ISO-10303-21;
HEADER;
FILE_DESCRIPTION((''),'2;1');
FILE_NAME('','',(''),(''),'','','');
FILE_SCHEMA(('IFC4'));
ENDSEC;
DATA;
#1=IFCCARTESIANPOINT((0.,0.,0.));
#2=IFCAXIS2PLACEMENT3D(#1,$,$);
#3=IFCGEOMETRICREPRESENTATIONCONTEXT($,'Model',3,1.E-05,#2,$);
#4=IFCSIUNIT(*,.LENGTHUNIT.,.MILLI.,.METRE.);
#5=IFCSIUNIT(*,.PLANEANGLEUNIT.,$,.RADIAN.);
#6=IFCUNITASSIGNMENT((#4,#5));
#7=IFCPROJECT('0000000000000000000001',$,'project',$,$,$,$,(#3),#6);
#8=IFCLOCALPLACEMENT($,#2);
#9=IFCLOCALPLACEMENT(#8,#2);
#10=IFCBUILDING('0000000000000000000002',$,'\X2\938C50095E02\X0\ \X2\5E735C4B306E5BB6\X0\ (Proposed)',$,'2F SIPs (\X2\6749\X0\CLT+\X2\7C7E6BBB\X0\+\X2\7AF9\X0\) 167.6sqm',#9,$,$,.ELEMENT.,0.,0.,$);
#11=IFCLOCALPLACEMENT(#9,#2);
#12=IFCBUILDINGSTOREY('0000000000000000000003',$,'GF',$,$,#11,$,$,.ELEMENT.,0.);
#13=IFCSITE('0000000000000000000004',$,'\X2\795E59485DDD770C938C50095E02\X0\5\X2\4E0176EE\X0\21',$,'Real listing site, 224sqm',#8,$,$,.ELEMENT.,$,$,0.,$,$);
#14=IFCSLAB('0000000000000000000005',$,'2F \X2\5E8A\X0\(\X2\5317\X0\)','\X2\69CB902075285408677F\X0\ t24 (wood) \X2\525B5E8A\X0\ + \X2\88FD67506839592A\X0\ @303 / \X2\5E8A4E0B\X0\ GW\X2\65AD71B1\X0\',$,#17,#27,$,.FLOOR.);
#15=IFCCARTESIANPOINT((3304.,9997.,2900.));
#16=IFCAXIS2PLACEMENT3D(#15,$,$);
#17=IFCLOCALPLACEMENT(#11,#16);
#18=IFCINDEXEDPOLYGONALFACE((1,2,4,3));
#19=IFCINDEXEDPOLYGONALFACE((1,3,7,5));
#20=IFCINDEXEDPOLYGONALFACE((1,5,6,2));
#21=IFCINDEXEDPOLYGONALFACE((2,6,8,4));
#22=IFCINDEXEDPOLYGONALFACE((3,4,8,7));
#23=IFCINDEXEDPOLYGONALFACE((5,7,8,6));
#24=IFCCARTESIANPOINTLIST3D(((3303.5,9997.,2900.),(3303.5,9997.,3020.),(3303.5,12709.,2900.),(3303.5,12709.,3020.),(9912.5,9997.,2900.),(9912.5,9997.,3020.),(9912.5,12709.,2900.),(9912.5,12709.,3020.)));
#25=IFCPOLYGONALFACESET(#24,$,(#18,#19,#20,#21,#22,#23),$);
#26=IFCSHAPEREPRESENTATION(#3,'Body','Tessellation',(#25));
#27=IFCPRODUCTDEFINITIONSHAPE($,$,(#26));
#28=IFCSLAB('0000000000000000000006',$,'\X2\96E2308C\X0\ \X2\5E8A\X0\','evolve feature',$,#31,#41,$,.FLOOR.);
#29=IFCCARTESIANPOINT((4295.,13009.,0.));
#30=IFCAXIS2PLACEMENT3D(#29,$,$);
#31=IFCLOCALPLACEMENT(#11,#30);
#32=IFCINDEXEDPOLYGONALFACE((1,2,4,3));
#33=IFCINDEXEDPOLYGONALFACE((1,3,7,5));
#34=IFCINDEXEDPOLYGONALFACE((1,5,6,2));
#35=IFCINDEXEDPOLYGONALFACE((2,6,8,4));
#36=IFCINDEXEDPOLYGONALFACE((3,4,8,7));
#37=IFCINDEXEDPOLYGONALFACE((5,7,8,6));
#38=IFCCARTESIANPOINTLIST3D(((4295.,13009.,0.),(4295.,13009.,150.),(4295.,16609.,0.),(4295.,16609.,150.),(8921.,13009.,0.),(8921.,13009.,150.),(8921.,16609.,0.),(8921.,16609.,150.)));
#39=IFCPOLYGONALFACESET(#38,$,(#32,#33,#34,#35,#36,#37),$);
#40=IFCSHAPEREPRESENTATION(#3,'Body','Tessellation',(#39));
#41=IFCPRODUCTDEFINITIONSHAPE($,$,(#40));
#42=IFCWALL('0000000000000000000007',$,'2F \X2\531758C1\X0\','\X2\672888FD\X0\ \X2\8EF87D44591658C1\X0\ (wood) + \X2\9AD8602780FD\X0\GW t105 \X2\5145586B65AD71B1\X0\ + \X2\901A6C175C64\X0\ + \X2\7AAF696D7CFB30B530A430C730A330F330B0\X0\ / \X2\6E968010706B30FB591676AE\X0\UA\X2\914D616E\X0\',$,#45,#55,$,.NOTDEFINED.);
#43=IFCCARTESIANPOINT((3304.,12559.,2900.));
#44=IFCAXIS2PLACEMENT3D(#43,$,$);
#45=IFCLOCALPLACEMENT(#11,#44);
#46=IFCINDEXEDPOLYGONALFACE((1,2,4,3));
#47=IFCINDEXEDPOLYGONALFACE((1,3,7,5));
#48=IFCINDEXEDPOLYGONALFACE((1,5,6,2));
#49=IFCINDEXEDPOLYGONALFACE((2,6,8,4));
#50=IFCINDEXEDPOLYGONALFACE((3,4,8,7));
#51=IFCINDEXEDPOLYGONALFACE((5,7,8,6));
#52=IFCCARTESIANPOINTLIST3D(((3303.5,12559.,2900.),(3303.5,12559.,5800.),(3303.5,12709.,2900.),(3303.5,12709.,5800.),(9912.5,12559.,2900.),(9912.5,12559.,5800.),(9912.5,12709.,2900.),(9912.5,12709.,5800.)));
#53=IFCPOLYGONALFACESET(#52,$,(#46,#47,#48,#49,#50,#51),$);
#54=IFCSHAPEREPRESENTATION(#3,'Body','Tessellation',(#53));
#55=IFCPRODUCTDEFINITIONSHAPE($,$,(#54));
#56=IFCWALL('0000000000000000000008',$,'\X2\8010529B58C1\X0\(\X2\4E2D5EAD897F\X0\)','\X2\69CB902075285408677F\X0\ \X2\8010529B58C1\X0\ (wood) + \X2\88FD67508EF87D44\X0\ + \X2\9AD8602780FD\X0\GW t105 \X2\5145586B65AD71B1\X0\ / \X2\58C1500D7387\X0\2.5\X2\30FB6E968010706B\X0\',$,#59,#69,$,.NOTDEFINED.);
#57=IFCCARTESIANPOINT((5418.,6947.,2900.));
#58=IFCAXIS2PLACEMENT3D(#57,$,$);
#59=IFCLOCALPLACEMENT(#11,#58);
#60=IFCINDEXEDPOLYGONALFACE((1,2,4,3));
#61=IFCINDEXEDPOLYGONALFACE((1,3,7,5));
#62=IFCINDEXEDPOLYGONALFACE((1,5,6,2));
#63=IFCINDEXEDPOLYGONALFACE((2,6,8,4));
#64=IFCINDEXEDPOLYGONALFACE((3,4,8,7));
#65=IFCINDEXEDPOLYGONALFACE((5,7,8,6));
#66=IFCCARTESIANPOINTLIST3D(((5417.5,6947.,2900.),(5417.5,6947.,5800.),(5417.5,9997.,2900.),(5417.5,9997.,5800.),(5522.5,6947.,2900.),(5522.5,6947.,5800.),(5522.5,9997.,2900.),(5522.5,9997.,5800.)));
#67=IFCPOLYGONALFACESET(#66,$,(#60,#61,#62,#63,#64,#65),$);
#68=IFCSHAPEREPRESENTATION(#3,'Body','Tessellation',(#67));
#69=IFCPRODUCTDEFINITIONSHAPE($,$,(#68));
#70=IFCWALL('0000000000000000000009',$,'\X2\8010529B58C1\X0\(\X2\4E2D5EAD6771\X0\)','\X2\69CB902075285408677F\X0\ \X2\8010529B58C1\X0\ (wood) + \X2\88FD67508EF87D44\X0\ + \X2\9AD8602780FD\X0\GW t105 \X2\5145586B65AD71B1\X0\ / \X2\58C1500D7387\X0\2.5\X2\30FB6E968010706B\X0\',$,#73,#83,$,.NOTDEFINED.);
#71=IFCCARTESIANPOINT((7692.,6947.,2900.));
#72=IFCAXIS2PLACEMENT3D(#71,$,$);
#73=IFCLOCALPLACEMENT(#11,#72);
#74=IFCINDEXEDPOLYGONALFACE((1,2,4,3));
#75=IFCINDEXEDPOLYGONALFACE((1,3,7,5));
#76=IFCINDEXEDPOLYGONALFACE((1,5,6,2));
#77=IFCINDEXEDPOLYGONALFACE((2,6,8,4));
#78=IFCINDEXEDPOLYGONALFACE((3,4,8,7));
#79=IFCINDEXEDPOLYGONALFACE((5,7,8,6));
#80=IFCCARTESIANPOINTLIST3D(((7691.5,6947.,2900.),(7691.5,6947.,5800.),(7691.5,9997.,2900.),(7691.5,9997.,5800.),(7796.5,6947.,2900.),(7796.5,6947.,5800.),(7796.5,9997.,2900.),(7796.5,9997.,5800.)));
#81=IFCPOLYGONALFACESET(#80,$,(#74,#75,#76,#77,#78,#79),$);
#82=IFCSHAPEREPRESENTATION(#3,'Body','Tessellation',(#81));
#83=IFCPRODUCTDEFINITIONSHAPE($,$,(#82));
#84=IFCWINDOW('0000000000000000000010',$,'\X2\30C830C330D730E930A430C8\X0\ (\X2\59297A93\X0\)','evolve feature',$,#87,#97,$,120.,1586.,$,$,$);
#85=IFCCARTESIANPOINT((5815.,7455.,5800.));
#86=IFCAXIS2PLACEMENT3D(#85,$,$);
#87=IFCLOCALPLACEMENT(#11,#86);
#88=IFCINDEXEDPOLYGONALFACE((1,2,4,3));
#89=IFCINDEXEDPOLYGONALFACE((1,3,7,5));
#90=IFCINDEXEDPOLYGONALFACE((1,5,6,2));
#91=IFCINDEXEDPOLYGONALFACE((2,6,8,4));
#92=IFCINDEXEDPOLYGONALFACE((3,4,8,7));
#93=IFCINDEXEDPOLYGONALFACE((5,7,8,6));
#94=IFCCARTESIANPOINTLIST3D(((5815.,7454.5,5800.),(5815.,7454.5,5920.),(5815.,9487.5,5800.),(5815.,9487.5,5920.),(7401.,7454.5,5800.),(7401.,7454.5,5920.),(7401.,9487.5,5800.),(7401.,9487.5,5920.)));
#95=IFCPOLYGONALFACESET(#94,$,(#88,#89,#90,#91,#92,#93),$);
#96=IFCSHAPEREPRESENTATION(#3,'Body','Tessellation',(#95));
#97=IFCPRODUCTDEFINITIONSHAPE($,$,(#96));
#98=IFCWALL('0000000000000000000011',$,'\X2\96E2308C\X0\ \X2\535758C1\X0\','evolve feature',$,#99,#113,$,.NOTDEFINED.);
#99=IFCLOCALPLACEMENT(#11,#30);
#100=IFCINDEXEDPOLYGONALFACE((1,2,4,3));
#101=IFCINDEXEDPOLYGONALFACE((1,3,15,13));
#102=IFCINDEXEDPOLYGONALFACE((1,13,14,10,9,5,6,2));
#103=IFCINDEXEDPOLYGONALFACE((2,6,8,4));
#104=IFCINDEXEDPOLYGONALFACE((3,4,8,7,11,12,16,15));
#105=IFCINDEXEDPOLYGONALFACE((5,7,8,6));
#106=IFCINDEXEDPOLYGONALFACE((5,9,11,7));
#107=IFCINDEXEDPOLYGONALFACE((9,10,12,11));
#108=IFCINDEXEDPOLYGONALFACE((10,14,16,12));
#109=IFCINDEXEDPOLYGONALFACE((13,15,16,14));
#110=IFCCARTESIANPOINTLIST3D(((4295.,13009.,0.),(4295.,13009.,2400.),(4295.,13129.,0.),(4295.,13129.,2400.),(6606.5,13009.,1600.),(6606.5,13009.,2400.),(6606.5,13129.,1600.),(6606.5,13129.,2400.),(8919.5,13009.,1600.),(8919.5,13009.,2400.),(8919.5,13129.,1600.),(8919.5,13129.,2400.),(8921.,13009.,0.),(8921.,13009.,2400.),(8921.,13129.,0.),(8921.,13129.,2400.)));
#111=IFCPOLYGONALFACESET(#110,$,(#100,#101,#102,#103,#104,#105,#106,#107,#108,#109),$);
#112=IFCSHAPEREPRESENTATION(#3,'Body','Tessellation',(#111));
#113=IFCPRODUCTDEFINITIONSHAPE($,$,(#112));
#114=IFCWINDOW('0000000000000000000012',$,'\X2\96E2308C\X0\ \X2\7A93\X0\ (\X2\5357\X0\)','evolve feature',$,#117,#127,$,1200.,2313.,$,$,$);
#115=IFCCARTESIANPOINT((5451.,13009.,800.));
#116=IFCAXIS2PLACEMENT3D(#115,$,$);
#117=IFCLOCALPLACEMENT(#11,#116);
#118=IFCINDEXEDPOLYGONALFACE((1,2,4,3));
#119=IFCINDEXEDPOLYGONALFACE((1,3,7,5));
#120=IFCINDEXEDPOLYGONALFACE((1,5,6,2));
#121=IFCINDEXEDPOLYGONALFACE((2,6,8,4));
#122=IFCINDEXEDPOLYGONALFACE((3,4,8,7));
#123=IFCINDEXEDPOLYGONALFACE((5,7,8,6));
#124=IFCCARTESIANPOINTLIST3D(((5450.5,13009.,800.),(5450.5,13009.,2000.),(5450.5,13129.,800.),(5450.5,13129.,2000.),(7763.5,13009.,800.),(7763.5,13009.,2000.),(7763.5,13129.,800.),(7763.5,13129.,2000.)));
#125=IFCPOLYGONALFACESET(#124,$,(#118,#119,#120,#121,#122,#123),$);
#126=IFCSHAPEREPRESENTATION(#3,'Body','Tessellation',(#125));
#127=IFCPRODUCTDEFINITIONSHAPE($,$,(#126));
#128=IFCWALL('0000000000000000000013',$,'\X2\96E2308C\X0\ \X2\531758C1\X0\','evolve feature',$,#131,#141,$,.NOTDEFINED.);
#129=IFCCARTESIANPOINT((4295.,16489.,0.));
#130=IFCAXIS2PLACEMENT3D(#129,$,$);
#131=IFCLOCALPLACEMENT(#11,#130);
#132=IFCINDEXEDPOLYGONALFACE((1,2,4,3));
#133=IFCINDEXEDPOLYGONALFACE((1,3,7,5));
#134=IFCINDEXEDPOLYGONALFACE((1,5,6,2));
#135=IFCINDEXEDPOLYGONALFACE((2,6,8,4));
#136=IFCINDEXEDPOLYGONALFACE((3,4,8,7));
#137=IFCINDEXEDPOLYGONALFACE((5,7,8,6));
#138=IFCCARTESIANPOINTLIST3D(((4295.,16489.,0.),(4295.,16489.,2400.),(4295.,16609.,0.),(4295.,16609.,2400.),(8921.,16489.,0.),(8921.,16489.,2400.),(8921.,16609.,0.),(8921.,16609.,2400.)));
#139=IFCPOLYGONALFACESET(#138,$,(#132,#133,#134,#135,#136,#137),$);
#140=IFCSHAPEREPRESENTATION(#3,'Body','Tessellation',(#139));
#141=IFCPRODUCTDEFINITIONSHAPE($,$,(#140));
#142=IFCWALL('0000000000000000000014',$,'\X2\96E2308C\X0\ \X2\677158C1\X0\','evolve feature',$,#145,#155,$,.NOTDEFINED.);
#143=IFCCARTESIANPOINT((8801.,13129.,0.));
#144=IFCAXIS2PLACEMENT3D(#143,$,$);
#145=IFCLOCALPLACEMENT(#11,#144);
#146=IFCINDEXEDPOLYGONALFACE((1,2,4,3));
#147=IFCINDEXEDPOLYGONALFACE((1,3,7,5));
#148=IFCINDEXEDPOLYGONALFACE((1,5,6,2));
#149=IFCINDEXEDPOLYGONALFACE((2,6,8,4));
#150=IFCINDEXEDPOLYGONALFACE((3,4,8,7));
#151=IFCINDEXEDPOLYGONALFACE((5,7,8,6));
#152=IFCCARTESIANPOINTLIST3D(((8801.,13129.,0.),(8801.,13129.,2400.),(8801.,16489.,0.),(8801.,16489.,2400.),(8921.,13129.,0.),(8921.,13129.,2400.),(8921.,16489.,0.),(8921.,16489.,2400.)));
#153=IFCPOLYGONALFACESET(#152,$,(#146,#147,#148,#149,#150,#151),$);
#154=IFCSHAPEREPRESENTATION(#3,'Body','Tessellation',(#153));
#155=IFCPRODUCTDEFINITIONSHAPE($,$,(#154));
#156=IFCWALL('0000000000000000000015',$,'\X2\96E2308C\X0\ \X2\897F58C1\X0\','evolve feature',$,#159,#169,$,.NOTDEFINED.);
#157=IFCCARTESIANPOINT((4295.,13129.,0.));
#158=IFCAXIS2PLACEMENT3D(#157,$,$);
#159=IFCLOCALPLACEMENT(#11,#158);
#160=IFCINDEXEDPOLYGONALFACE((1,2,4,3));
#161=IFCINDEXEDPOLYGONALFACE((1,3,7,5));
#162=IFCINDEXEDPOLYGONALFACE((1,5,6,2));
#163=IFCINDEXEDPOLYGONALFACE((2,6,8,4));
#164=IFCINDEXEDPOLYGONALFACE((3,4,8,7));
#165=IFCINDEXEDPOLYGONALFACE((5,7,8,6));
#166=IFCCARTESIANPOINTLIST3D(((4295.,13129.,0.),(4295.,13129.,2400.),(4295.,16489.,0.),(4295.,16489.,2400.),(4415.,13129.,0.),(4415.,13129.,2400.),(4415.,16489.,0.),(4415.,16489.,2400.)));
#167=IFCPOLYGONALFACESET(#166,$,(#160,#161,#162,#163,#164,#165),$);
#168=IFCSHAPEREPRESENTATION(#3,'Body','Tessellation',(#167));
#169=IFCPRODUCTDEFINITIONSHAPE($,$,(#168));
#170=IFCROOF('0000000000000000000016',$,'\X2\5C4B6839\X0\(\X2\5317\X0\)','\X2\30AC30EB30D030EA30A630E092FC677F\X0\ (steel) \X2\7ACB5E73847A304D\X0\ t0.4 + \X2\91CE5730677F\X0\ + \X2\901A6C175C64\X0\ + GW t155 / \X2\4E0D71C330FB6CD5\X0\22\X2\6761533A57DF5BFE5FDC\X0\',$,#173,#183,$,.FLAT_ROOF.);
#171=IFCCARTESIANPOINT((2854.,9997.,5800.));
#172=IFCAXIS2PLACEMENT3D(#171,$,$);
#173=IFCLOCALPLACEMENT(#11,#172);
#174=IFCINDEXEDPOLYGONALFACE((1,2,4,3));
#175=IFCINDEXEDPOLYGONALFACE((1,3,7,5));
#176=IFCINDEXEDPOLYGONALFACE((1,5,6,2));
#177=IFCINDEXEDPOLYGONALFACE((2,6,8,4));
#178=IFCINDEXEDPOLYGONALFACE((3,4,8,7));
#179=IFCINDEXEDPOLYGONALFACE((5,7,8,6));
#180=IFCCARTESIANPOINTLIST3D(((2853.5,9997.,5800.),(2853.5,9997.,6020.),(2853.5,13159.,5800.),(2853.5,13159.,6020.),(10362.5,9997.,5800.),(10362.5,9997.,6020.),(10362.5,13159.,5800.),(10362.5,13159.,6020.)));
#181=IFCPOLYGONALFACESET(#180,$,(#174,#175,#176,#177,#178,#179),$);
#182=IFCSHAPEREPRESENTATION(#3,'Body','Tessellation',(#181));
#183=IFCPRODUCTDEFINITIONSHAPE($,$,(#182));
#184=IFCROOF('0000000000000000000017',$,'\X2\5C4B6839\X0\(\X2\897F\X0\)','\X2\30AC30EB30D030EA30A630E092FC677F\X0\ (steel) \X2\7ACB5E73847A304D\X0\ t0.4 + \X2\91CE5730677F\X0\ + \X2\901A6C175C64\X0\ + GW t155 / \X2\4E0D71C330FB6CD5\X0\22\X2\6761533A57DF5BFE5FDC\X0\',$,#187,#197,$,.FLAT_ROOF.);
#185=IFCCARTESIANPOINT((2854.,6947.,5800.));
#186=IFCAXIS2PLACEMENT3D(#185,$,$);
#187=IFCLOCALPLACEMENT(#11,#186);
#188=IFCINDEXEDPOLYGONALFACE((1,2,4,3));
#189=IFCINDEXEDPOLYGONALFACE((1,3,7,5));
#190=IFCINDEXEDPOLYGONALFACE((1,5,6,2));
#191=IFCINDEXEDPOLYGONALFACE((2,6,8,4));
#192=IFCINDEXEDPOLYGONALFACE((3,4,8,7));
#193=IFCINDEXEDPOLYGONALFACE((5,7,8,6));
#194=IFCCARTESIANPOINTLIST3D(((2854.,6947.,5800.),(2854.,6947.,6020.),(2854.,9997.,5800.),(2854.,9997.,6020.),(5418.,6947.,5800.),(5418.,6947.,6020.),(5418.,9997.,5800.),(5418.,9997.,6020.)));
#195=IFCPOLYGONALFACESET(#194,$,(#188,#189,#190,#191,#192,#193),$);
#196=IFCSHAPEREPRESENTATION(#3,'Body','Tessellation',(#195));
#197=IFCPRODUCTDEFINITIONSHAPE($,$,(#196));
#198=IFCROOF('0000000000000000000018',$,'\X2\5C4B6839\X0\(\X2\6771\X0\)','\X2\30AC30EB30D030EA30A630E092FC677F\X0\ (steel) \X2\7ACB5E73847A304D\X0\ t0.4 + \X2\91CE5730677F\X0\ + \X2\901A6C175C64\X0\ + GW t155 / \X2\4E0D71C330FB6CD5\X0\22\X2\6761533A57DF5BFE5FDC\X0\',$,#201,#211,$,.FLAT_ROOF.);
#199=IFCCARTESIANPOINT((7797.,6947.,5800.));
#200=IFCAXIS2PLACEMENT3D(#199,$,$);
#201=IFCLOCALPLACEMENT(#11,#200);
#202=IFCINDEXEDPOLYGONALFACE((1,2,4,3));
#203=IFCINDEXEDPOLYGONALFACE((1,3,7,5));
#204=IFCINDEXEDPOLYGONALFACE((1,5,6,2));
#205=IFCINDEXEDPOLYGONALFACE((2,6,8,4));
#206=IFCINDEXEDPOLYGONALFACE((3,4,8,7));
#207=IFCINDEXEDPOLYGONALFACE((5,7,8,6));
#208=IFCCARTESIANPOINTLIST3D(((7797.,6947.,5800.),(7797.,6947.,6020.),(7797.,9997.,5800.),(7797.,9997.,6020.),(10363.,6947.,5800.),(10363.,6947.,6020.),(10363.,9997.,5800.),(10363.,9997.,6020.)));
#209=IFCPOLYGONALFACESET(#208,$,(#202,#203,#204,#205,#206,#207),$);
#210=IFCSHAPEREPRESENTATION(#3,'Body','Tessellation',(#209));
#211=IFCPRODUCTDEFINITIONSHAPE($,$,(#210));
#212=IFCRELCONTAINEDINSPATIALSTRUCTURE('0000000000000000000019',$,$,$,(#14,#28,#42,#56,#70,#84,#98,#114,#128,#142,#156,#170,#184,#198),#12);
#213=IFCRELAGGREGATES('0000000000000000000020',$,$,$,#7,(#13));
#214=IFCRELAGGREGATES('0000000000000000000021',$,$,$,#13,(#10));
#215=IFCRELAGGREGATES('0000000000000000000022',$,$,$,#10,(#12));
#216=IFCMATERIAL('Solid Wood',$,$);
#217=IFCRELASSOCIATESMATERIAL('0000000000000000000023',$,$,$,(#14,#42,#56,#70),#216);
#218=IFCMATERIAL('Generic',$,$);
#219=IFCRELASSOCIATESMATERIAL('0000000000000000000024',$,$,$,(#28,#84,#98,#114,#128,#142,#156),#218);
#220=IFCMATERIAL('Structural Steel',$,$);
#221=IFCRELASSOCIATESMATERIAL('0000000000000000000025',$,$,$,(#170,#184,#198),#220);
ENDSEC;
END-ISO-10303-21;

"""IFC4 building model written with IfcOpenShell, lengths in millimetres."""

from ifc_helpers import new_model, si_unit, frame, frame_2d, origin, place, context, project, spatial, rectangle, extrude, material, element, fill, save


model = new_model("IFC4")

# Units and contexts
model_context = context("Model", 3, precision=1e-05, world=origin())
ifc_project = project(units=[si_unit("LENGTHUNIT", "METRE", prefix="MILLI"), si_unit("PLANEANGLEUNIT", "RADIAN")], contexts=[model_context])

# Site, building, storey
site_placement = place(None, origin())
site = spatial("IfcSite", under=ifc_project, at=site_placement, Name="神奈川県鎌倉市5丁目21", ObjectType="Real listing site, 224sqm", CompositionType="ELEMENT", RefElevation=0.0)
building_placement = place(site_placement, origin())
building = spatial("IfcBuilding", under=site, at=building_placement, Name="鎌倉市 平屋の家 (Proposed)", ObjectType="2F SIPs (杉CLT+籾殻+竹) 167.6sqm", CompositionType="ELEMENT", ElevationOfRefHeight=0.0, ElevationOfTerrain=0.0)
storey_placement = place(building_placement, origin())
storey = spatial("IfcBuildingStorey", under=building, at=storey_placement, Name="GF", CompositionType="ELEMENT", Elevation=0.0)

# Slabs
ifc_material_1 = material(Name="Solid Wood")
slab_1_placement = place(storey_placement, frame((3304.0, 9997.0, 2900.0)))
element("IfcSlab", 1, at=slab_1_placement, inside=storey, material=ifc_material_1, Name="2F 床(北)", Description="構造用合板 t24 (wood) 剛床 + 製材根太 @303 / 床下 GW断熱", PredefinedType="FLOOR", context=model_context, shape_type="SweptSolid", body=[
    extrude(rectangle(XDim=6609.0, YDim=2712.0, at=frame_2d((3304.0, 1356.0))), frame((3304.0, 9997.0, 2900.0)), (0.0, 0.0, 1.0), 120.0),
])
ifc_material_2 = material(Name="Generic")
slab_2_placement = place(storey_placement, frame((4295.0, 13009.0, 0.0)))
element("IfcSlab", 2, at=slab_2_placement, inside=storey, material=ifc_material_2, Name="離れ 床", Description="evolve feature", PredefinedType="FLOOR", context=model_context, shape_type="SweptSolid", body=[
    extrude(rectangle(XDim=4626.0, YDim=3600.0, at=frame_2d((2313.0, 1800.0))), frame((4295.0, 13009.0, 0.0)), (0.0, 0.0, 1.0), 150.0),
])

# Wall
wall_1_placement = place(storey_placement, frame((3304.0, 12559.0, 2900.0)))
element("IfcWall", 3, at=wall_1_placement, inside=storey, material=ifc_material_1, Name="2F 北壁", Description="木製 軸組外壁 (wood) + 高性能GW t105 充填断熱 + 通気層 + 窯業系サイディング / 準耐火・外皮UA配慮", PredefinedType="NOTDEFINED", context=model_context, shape_type="SweptSolid", body=[
    extrude(rectangle(XDim=6609.0, YDim=150.0, at=frame_2d((3304.0, 75.0))), frame((3304.0, 12559.0, 2900.0)), (0.0, 0.0, 1.0), 2900.0),
])

# Walls
wall_2_placement = place(storey_placement, frame((5418.0, 6947.0, 2900.0)))
element("IfcWall", 4, at=wall_2_placement, inside=storey, material=ifc_material_1, Name="耐力壁(中庭西)", Description="構造用合板 耐力壁 (wood) + 製材軸組 + 高性能GW t105 充填断熱 / 壁倍率2.5・準耐火", PredefinedType="NOTDEFINED", context=model_context, shape_type="SweptSolid", body=[
    extrude(rectangle(XDim=105.0, YDim=3050.0, at=frame_2d((52.0, 1525.0))), frame((5418.0, 6947.0, 2900.0)), (0.0, 0.0, 1.0), 2900.0),
])
wall_3_placement = place(storey_placement, frame((7692.0, 6947.0, 2900.0)))
element("IfcWall", 5, at=wall_3_placement, inside=storey, material=ifc_material_1, Name="耐力壁(中庭東)", Description="構造用合板 耐力壁 (wood) + 製材軸組 + 高性能GW t105 充填断熱 / 壁倍率2.5・準耐火", PredefinedType="NOTDEFINED", context=model_context, shape_type="SweptSolid", body=[
    extrude(rectangle(XDim=105.0, YDim=3050.0, at=frame_2d((52.0, 1525.0))), frame((7692.0, 6947.0, 2900.0)), (0.0, 0.0, 1.0), 2900.0),
])

# Window
window_1_placement = place(storey_placement, frame((5815.0, 7455.0, 5800.0)))
element("IfcWindow", 6, at=window_1_placement, inside=storey, material=ifc_material_2, Name="トップライト (天窓)", Description="evolve feature", OverallHeight=120.0, OverallWidth=1586.0, context=model_context, shape_type="SweptSolid", body=[
    extrude(rectangle(XDim=1586.0, YDim=2033.0, at=frame_2d((793.0, 1016.0))), frame((5815.0, 7455.0, 5800.0)), (0.0, 0.0, 1.0), 120.0),
])

# Wall, opening, window
wall_4_placement = place(storey_placement, frame((4295.0, 13009.0, 0.0)))
wall_4 = element("IfcWall", 7, at=wall_4_placement, inside=storey, material=ifc_material_2, Name="離れ 南壁", Description="evolve feature", PredefinedType="NOTDEFINED", context=model_context, shape_type="SweptSolid", body=[
    extrude(rectangle(XDim=4626.0, YDim=120.0, at=frame_2d((2313.0, 60.0))), frame((4295.0, 13009.0, 0.0)), (0.0, 0.0, 1.0), 2400.0),
])
opening_1_placement = place(storey_placement, frame((5451.0, 13009.0, 800.0)))
opening_1 = element("IfcOpeningElement", 8, at=opening_1_placement, cuts=wall_4, PredefinedType="NOTDEFINED", context=model_context, shape_type="SweptSolid", body=[
    extrude(rectangle(XDim=2313.0, YDim=120.0, at=frame_2d((1156.0, 60.0))), frame((5451.0, 13009.0, 800.0)), (0.0, 0.0, 1.0), 1200.0),
])
window_2_placement = place(storey_placement, frame((5451.0, 13009.0, 800.0)))
window_2 = element("IfcWindow", 9, at=window_2_placement, inside=storey, material=ifc_material_2, Name="離れ 窓 (南)", Description="evolve feature", OverallHeight=1200.0, OverallWidth=2313.0, context=model_context, shape_type="SweptSolid", body=[
    extrude(rectangle(XDim=2313.0, YDim=120.0, at=frame_2d((1156.0, 60.0))), frame((5451.0, 13009.0, 800.0)), (0.0, 0.0, 1.0), 1200.0),
])
fill(opening_1, window_2)

# Walls
wall_5_placement = place(storey_placement, frame((4295.0, 16489.0, 0.0)))
element("IfcWall", 10, at=wall_5_placement, inside=storey, material=ifc_material_2, Name="離れ 北壁", Description="evolve feature", PredefinedType="NOTDEFINED", context=model_context, shape_type="SweptSolid", body=[
    extrude(rectangle(XDim=4626.0, YDim=120.0, at=frame_2d((2313.0, 60.0))), frame((4295.0, 16489.0, 0.0)), (0.0, 0.0, 1.0), 2400.0),
])
wall_6_placement = place(storey_placement, frame((8801.0, 13129.0, 0.0)))
element("IfcWall", 11, at=wall_6_placement, inside=storey, material=ifc_material_2, Name="離れ 東壁", Description="evolve feature", PredefinedType="NOTDEFINED", context=model_context, shape_type="SweptSolid", body=[
    extrude(rectangle(XDim=120.0, YDim=3360.0, at=frame_2d((60.0, 1680.0))), frame((8801.0, 13129.0, 0.0)), (0.0, 0.0, 1.0), 2400.0),
])
wall_7_placement = place(storey_placement, frame((4295.0, 13129.0, 0.0)))
element("IfcWall", 12, at=wall_7_placement, inside=storey, material=ifc_material_2, Name="離れ 西壁", Description="evolve feature", PredefinedType="NOTDEFINED", context=model_context, shape_type="SweptSolid", body=[
    extrude(rectangle(XDim=120.0, YDim=3360.0, at=frame_2d((60.0, 1680.0))), frame((4295.0, 13129.0, 0.0)), (0.0, 0.0, 1.0), 2400.0),
])

# Roofs
ifc_material_3 = material(Name="Structural Steel")
for number, where, name in (
    (13, (2854.0, 9997.0, 5800.0), "屋根(北)"),
):
    element("IfcRoof", number, at=place(storey_placement, frame(where)), inside=storey, material=ifc_material_3, Name=name, Description="ガルバリウム鋼板 (steel) 立平葺き t0.4 + 野地板 + 通気層 + GW t155 / 不燃・法22条区域対応", PredefinedType="FLAT_ROOF", context=model_context, shape_type="SweptSolid", body=[
        extrude(rectangle(XDim=7509.0, YDim=3162.0, at=frame_2d((3754.0, 1581.0))), frame((2854.0, 9997.0, 5800.0)), (0.0, 0.0, 1.0), 220.0),
    ])
roof_1_placement = place(storey_placement, frame((2854.0, 6947.0, 5800.0)))
element("IfcRoof", 14, at=roof_1_placement, inside=storey, material=ifc_material_3, Name="屋根(西)", Description="ガルバリウム鋼板 (steel) 立平葺き t0.4 + 野地板 + 通気層 + GW t155 / 不燃・法22条区域対応", PredefinedType="FLAT_ROOF", context=model_context, shape_type="SweptSolid", body=[
    extrude(rectangle(XDim=2564.0, YDim=3050.0, at=frame_2d((1282.0, 1525.0))), frame((2854.0, 6947.0, 5800.0)), (0.0, 0.0, 1.0), 220.0),
])
roof_2_placement = place(storey_placement, frame((7797.0, 6947.0, 5800.0)))
element("IfcRoof", 15, at=roof_2_placement, inside=storey, material=ifc_material_3, Name="屋根(東)", Description="ガルバリウム鋼板 (steel) 立平葺き t0.4 + 野地板 + 通気層 + GW t155 / 不燃・法22条区域対応", PredefinedType="FLAT_ROOF", context=model_context, shape_type="SweptSolid", body=[
    extrude(rectangle(XDim=2566.0, YDim=3050.0, at=frame_2d((1283.0, 1525.0))), frame((7797.0, 6947.0, 5800.0)), (0.0, 0.0, 1.0), 220.0),
])

save(model, "model.ifc")
